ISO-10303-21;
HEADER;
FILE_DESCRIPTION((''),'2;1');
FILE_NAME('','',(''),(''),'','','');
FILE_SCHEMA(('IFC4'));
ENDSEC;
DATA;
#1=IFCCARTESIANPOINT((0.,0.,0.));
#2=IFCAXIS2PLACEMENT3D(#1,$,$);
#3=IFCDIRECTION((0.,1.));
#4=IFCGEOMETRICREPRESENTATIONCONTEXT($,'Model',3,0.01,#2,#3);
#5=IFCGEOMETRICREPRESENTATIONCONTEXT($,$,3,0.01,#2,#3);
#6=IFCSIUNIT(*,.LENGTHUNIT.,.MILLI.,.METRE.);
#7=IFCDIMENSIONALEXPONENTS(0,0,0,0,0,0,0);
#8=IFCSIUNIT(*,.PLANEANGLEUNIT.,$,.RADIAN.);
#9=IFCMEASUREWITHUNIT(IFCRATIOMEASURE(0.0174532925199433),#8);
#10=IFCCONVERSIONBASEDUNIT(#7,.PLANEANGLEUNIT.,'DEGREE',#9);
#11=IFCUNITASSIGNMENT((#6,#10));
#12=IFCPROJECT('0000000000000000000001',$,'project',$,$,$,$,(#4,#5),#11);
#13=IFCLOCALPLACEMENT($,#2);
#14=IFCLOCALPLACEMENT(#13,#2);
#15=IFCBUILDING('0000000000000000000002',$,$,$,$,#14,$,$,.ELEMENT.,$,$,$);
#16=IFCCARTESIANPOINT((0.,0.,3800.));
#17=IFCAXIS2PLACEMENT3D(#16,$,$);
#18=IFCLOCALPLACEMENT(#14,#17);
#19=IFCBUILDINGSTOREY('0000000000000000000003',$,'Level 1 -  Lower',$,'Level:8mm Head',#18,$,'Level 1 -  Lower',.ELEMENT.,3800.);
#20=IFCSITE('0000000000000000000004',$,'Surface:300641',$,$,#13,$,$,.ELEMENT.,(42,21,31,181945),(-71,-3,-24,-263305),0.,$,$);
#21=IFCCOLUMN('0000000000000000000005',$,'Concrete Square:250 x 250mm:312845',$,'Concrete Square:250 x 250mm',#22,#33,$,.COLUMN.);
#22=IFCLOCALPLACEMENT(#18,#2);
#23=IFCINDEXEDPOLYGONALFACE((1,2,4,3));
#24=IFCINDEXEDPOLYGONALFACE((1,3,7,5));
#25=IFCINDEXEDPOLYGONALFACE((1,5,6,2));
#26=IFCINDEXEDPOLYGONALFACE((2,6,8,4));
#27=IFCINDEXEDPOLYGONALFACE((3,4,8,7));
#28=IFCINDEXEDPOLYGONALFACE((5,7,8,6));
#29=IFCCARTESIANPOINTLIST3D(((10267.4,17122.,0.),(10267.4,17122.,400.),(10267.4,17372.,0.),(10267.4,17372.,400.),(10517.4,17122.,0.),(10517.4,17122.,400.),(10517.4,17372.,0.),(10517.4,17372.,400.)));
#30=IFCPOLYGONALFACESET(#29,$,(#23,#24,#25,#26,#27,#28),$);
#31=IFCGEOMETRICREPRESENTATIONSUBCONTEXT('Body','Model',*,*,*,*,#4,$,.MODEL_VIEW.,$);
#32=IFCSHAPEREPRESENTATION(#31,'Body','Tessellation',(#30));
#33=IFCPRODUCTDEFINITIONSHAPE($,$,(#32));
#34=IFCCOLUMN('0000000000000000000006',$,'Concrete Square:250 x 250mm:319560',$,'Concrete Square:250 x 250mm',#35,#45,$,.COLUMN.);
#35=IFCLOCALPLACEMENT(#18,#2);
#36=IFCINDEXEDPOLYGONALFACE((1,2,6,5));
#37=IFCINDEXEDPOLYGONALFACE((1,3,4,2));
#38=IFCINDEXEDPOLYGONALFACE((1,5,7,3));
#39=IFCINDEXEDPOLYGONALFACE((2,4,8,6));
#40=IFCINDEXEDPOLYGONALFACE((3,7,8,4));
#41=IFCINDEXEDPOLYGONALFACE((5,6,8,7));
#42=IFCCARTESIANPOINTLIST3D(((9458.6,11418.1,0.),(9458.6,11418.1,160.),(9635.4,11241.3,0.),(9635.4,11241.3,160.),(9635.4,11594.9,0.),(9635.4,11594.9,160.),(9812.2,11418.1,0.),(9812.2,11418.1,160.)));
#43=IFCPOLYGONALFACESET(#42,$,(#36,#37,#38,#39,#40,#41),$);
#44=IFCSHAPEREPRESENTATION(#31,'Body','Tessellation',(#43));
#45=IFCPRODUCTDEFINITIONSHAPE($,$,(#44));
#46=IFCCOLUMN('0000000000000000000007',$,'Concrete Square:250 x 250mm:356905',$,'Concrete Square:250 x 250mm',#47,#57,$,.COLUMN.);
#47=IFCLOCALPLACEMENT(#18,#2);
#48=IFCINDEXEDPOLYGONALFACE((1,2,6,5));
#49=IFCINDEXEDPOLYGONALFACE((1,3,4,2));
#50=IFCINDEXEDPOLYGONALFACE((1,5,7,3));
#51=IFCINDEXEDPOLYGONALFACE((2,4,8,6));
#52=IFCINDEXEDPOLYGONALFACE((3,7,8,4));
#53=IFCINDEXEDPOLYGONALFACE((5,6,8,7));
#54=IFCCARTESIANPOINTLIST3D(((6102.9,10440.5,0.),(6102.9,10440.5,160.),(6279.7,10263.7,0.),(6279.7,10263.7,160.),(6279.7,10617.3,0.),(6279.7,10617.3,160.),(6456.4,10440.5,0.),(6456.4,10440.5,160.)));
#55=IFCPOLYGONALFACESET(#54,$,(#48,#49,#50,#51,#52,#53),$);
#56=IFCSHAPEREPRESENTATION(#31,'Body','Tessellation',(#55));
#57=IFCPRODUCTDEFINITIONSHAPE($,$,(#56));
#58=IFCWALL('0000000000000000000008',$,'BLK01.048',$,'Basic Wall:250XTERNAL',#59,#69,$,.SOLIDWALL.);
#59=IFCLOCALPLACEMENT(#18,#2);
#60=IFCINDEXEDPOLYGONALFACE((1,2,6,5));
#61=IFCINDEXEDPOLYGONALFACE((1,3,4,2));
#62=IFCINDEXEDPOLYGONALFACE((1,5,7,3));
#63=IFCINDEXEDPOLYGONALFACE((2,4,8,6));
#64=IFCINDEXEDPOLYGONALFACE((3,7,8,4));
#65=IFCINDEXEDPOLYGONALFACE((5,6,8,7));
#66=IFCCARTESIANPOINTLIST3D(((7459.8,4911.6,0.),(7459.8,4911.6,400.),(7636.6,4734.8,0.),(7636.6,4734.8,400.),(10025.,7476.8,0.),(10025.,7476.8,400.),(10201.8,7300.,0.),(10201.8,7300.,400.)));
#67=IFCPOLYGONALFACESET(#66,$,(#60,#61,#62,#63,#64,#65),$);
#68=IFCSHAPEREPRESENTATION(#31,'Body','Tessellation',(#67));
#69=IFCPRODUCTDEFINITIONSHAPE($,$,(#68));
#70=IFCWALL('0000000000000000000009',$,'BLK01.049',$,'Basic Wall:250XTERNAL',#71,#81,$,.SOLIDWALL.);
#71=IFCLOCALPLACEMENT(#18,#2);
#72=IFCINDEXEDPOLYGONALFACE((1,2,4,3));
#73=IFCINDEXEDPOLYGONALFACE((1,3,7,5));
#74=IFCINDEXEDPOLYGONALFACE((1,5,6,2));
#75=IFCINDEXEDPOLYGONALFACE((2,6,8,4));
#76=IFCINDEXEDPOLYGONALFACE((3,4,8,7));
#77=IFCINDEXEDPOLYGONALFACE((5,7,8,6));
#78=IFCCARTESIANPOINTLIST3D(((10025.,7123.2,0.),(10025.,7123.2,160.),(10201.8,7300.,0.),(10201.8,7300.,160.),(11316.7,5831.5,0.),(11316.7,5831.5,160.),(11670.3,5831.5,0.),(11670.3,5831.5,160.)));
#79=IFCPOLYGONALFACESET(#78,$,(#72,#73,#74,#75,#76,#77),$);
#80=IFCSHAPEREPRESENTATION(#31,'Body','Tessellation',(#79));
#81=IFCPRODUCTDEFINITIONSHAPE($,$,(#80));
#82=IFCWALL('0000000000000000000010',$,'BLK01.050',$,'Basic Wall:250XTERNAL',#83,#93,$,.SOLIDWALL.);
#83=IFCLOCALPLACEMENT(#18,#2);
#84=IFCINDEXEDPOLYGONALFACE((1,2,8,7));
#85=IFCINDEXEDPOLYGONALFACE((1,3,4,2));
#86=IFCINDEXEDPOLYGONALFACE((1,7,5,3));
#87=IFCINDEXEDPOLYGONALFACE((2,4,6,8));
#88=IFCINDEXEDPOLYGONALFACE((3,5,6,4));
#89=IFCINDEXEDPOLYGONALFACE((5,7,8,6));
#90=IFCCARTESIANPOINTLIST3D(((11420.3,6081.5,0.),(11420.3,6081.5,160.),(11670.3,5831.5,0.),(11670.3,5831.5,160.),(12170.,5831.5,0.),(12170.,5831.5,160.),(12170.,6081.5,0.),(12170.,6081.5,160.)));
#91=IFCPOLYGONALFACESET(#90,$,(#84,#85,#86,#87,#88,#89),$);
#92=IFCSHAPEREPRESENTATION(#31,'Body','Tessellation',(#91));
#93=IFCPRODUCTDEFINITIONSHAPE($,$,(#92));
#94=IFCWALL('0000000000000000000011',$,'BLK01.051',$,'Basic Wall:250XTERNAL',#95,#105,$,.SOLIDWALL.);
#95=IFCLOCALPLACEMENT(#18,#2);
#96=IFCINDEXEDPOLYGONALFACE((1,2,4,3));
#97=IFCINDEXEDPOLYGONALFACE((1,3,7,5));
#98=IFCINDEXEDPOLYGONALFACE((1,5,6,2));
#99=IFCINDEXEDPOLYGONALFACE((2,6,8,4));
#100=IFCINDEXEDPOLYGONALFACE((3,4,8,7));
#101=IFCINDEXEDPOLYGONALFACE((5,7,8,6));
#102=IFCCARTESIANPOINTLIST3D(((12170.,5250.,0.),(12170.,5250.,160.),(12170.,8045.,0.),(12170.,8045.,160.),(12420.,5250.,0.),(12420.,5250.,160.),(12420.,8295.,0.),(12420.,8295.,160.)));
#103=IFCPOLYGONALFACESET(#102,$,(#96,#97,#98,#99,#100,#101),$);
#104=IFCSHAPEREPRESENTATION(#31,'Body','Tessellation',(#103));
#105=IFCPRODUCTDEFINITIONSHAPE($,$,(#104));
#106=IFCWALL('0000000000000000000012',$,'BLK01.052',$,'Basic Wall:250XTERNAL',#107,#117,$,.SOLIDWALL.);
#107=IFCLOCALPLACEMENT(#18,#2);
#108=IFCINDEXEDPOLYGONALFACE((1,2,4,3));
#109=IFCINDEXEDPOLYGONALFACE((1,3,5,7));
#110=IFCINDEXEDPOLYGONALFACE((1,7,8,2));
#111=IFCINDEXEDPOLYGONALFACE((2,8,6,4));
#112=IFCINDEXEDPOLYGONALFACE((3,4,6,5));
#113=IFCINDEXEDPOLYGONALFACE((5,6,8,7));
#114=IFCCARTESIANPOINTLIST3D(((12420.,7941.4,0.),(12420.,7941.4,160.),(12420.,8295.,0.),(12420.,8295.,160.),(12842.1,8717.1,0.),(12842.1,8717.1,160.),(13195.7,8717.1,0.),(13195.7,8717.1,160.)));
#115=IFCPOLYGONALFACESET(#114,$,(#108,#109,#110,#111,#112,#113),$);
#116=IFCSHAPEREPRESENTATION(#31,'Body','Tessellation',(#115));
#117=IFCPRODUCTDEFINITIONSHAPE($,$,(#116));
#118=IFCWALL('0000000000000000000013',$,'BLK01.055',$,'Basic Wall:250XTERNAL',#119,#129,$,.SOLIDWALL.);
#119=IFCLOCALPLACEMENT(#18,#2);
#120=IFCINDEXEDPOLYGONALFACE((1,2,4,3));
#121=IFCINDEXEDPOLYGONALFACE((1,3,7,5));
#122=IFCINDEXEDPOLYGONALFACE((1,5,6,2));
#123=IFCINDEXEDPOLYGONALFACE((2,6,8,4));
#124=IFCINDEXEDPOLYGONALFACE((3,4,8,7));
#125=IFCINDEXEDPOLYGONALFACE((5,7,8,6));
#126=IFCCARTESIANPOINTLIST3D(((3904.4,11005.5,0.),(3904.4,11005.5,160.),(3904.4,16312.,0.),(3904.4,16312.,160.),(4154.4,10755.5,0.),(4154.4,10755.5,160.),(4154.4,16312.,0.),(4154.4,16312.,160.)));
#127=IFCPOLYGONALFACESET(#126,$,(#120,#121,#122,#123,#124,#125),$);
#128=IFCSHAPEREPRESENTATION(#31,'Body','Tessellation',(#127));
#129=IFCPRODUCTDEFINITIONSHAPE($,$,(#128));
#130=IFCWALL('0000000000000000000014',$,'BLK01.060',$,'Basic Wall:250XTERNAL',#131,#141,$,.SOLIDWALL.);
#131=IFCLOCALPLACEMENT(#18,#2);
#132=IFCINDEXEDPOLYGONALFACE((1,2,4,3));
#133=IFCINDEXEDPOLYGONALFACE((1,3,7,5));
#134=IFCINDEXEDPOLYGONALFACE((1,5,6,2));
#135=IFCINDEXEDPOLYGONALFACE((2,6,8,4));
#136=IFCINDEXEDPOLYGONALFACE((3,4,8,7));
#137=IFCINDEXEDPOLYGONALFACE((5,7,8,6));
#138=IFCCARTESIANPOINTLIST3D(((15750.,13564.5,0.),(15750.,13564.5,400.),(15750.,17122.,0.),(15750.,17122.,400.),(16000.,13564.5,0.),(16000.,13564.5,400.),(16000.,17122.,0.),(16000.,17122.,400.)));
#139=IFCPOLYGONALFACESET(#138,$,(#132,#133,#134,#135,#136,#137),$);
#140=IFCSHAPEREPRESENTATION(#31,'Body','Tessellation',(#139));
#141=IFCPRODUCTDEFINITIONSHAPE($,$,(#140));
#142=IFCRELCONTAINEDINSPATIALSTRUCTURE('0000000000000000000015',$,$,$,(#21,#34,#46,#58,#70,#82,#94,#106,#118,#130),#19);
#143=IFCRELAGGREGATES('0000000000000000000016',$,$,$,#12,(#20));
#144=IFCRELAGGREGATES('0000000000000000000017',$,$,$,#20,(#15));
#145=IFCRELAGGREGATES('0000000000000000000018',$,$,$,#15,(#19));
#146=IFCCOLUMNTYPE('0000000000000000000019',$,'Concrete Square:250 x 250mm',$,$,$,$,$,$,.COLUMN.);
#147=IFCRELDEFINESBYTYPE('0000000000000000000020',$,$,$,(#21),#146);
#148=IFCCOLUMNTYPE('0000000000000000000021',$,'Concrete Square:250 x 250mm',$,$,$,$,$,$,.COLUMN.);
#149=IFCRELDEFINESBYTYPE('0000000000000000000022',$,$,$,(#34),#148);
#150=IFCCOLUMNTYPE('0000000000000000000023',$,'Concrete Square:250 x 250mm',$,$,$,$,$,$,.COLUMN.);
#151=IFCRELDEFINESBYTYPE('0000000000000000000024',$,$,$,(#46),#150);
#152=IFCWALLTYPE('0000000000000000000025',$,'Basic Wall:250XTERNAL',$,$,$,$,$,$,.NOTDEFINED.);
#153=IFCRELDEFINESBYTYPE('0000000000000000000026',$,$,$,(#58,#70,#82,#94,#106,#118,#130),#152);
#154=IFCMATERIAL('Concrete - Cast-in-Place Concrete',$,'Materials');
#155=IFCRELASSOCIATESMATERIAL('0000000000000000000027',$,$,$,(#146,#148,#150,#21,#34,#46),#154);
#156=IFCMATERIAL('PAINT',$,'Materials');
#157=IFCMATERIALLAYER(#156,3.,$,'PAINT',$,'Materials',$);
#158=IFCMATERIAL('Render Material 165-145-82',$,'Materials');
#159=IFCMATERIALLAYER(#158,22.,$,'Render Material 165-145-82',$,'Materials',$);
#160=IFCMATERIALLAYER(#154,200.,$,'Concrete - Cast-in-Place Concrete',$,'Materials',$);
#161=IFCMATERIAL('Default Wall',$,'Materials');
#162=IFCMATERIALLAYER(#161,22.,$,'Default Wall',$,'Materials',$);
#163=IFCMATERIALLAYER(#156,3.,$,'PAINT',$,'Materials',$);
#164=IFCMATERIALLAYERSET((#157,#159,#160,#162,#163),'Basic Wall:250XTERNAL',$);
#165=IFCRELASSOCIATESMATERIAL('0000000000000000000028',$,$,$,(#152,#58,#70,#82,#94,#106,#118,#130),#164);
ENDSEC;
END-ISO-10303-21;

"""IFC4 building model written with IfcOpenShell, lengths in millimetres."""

from ifc_helpers import new_model, entity, si_unit, converted_unit, direction, frame, frame_2d, origin, origin_2d_with_axis, place, context, subcontext, project, spatial, polyline, rectangle, outline, extrude, clip, halfspace, bounded_halfspace, source, transform, mapped, material, layer, layer_set, layer_usage, material_profile, profile_set, profile_usage, type_object, type_shapes, element, save


model = new_model("IFC4")

# Units and contexts
model_context = context("Model", 3, precision=0.01, world=origin(), true_north=direction((0.0, 1.0)))
context_of_model = context(None, 3, precision=0.01, world=origin(), true_north=direction((0.0, 1.0)))
body_context = subcontext(model_context, "Body", "Model", "MODEL_VIEW")
ifc_project = project(units=[si_unit("LENGTHUNIT", "METRE", prefix="MILLI"), converted_unit("PLANEANGLEUNIT", "DEGREE", entity("IfcRatioMeasure", 0.0174532925199433), si_unit("PLANEANGLEUNIT", "RADIAN"), dimensions=[0, 0, 0, 0, 0, 0, 0])], contexts=[model_context, context_of_model])

# Site, building, storey
site_placement = place(None, origin())
site = spatial("IfcSite", under=ifc_project, at=site_placement, Name="Surface:300641", CompositionType="ELEMENT", RefLatitude=(42, 21, 31, 181945), RefLongitude=(-71, -3, -24, -263305), RefElevation=0.0)
building_placement = place(site_placement, origin())
building = spatial("IfcBuilding", under=site, at=building_placement, CompositionType="ELEMENT")
storey_placement = place(building_placement, frame((0.0, 0.0, 3800.0)))
storey = spatial("IfcBuildingStorey", under=building, at=storey_placement, Name="Level 1 -  Lower", ObjectType="Level:8mm Head", LongName="Level 1 -  Lower", CompositionType="ELEMENT", Elevation=3800.0)

# Columns
ifc_material_1 = material(Name="Concrete - Cast-in-Place Concrete", Category="Materials")
ifc_material_profile_1 = material_profile(ifc_material_1, rectangle(XDim=250.0, YDim=250.0, at=frame_2d((0.0, 0.0), x_axis=(1.0, 0.0))), Name="250 x 250mm")
ifc_profile_set_1 = profile_set([ifc_material_profile_1], Name="250 x 250mm")
ifc_profile_usage_1 = profile_usage(ifc_profile_set_1)
column_type_1 = type_object("IfcColumnType", Name="Concrete Square:250 x 250mm", PredefinedType="COLUMN", material=ifc_profile_set_1)
shared_shape_1 = source(origin(), body_context, "Body", "SweptSolid", [
    extrude(rectangle(XDim=250.0, YDim=250.0, at=origin_2d_with_axis()), frame((10392.4, 17247.0, 3800.0), z_axis=(0.0, 0.0, 1.0), x_axis=(0.0, -1.0, 0.0)), (0.0, 0.0, 1.0), 400.0),
])
type_shapes(column_type_1, [shared_shape_1])
column_1_placement = place(storey_placement, frame((0.0, 0.0, -3800.0)))
element("IfcColumn", 1, at=column_1_placement, inside=storey, type_object=column_type_1, material=ifc_profile_usage_1, Name="Concrete Square:250 x 250mm:312845", ObjectType="Concrete Square:250 x 250mm", PredefinedType="COLUMN", context=body_context, shape_type="MappedRepresentation", body=[
    mapped(shared_shape_1, transform((0.0, 0.0, 0.0), scale=1.0)),
])
ifc_profile_usage_2 = profile_usage(ifc_profile_set_1)
column_type_2 = type_object("IfcColumnType", Name="Concrete Square:250 x 250mm", PredefinedType="COLUMN", material=ifc_profile_set_1)
shared_shape_2 = source(origin(), body_context, "Body", "SweptSolid", [
    extrude(rectangle(XDim=250.0, YDim=250.0, at=frame_2d((0.0, 0.0), x_axis=(1.0, 0.0))), frame((9635.4, 11418.1, 3800.0), z_axis=(0.0, 0.0, 1.0), x_axis=(-0.707107, 0.707107, 0.0)), (0.0, 0.0, 1.0), 160.0),
])
type_shapes(column_type_2, [shared_shape_2])
column_2_placement = place(storey_placement, frame((0.0, 0.0, -3800.0)))
element("IfcColumn", 2, at=column_2_placement, inside=storey, type_object=column_type_2, material=ifc_profile_usage_2, Name="Concrete Square:250 x 250mm:319560", ObjectType="Concrete Square:250 x 250mm", PredefinedType="COLUMN", context=body_context, shape_type="MappedRepresentation", body=[
    mapped(shared_shape_2, transform((0.0, 0.0, 0.0), scale=1.0)),
])
ifc_profile_usage_3 = profile_usage(ifc_profile_set_1)
column_type_3 = type_object("IfcColumnType", Name="Concrete Square:250 x 250mm", PredefinedType="COLUMN", material=ifc_profile_set_1)
shared_shape_3 = source(origin(), body_context, "Body", "SweptSolid", [
    extrude(rectangle(XDim=250.0, YDim=250.0, at=origin_2d_with_axis()), frame((6279.7, 10440.5, 3800.0), z_axis=(0.0, 0.0, 1.0), x_axis=(-0.707107, 0.707107, 0.0)), (0.0, 0.0, 1.0), 160.0),
])
type_shapes(column_type_3, [shared_shape_3])
column_3_placement = place(storey_placement, frame((0.0, 0.0, -3800.0)))
element("IfcColumn", 3, at=column_3_placement, inside=storey, type_object=column_type_3, material=ifc_profile_usage_3, Name="Concrete Square:250 x 250mm:356905", ObjectType="Concrete Square:250 x 250mm", PredefinedType="COLUMN", context=body_context, shape_type="MappedRepresentation", body=[
    mapped(shared_shape_3, transform((0.0, 0.0, 0.0), scale=1.0)),
])

# Walls
ifc_material_2 = material(Name="PAINT", Category="Materials")
ifc_layer_1 = layer(ifc_material_2, 3.0, Name="PAINT", Category="Materials")
ifc_material_3 = material(Name="Render Material 165-145-82", Category="Materials")
ifc_layer_2 = layer(ifc_material_3, 22.0, Name="Render Material 165-145-82", Category="Materials")
ifc_layer_3 = layer(ifc_material_1, 200.0, Name="Concrete - Cast-in-Place Concrete", Category="Materials")
ifc_material_4 = material(Name="Default Wall", Category="Materials")
ifc_layer_4 = layer(ifc_material_4, 22.0, Name="Default Wall", Category="Materials")
ifc_layer_5 = layer(ifc_material_2, 3.0, Name="PAINT", Category="Materials")
ifc_layer_set_1 = layer_set([ifc_layer_1, ifc_layer_2, ifc_layer_3, ifc_layer_4, ifc_layer_5], Name="Basic Wall:250XTERNAL")
wall_type_1 = type_object("IfcWallType", Name="Basic Wall:250XTERNAL", PredefinedType="NOTDEFINED", material=ifc_layer_set_1)
ifc_layer_usage_1 = layer_usage(ifc_layer_set_1, "AXIS2", "NEGATIVE", 125.0)
wall_1_placement = place(storey_placement, frame((7548.2, 4823.2, 0.0), z_axis=(0.0, 0.0, 1.0), x_axis=(0.707107, 0.707107, 0.0)))
element("IfcWall", 4, at=wall_1_placement, inside=storey, type_object=wall_type_1, material=ifc_layer_usage_1, Name="BLK01.048", ObjectType="Basic Wall:250XTERNAL", PredefinedType="SOLIDWALL", context=body_context, shape_type="Clipping", body=[
    clip(extrude(rectangle(XDim=3627.7, YDim=250.0, at=frame_2d((1813.8, 0.0), x_axis=(-1.0, 0.0))), origin(), (0.0, 0.0, 1.0), 400.0), halfspace(frame((0.0, 0.0, -3200.0)), True)),
])
ifc_layer_usage_2 = layer_usage(ifc_layer_set_1, "AXIS2", "NEGATIVE", 125.0)
wall_2_placement = place(storey_placement, frame((10113.4, 7211.6, 0.0), z_axis=(0.0, 0.0, 1.0), x_axis=(0.707107, -0.707107, 0.0)))
element("IfcWall", 5, at=wall_2_placement, inside=storey, type_object=wall_type_1, material=ifc_layer_usage_2, Name="BLK01.049", ObjectType="Basic Wall:250XTERNAL", PredefinedType="SOLIDWALL", context=body_context, shape_type="Clipping", body=[
    clip(clip(extrude(outline(polyline([(0.0, -125.0), (1826.8, -125.0), (2076.8, 125.0), (1723.2, 125.0), (0.0, 125.0), (0.0, -125.0)])), origin(), (0.0, 0.0, 1.0), 160.0), bounded_halfspace(frame((0.0, -125.0, 160.0), z_axis=(0.0, 0.0, -1.0), x_axis=(0.707107, -0.707107, 0.0)), True, frame((0.0, -125.0, 160.0)), polyline([(0.0, 0.0), (1826.8, 0.0), (2076.8, 250.0), (1723.2, 250.0), (0.0, 250.0), (0.0, 0.0)]))), halfspace(frame((0.0, 0.0, -3200.0)), True)),
])
ifc_layer_usage_3 = layer_usage(ifc_layer_set_1, "AXIS2", "NEGATIVE", 125.0)
wall_3_placement = place(storey_placement, frame((11420.3, 5956.5, 0.0)))
element("IfcWall", 6, at=wall_3_placement, inside=storey, type_object=wall_type_1, material=ifc_layer_usage_3, Name="BLK01.050", ObjectType="Basic Wall:250XTERNAL", PredefinedType="SOLIDWALL", context=body_context, shape_type="Clipping", body=[
    clip(clip(extrude(outline(polyline([(749.7, -125.0), (749.7, 125.0), (0.0, 125.0), (250.0, -125.0), (749.7, -125.0)])), origin(), (0.0, 0.0, 1.0), 160.0), bounded_halfspace(frame((250.0, -125.0, 160.0), z_axis=(0.0, 0.0, -1.0), x_axis=(0.0, -1.0, 0.0)), True, frame((250.0, -125.0, 160.0)), polyline([(0.0, 0.0), (499.7, 0.0), (499.7, 250.0), (-250.0, 250.0), (0.0, 0.0)]))), halfspace(frame((0.0, 0.0, -3200.0)), True)),
])
ifc_layer_usage_4 = layer_usage(ifc_layer_set_1, "AXIS2", "NEGATIVE", 125.0)
wall_4_placement = place(storey_placement, frame((12295.0, 5250.0, 0.0), z_axis=(0.0, 0.0, 1.0), x_axis=(0.0, 1.0, 0.0)))
element("IfcWall", 7, at=wall_4_placement, inside=storey, type_object=wall_type_1, material=ifc_layer_usage_4, Name="BLK01.051", ObjectType="Basic Wall:250XTERNAL", PredefinedType="SOLIDWALL", context=body_context, shape_type="Clipping", body=[
    clip(clip(extrude(outline(polyline([(3045.0, -125.0), (2795.0, 125.0), (831.5, 125.0), (581.5, 125.0), (0.0, 125.0), (0.0, -125.0), (2691.4, -125.0), (3045.0, -125.0)])), origin(), (0.0, 0.0, 1.0), 160.0), bounded_halfspace(frame((0.0, -125.0, 160.0), z_axis=(0.0, 0.0, -1.0), x_axis=(-1.0, 0.0, 0.0)), True, frame((0.0, -125.0, 160.0)), polyline([(0.0, 0.0), (2691.4, 0.0), (3045.0, 0.0), (2795.0, 250.0), (831.5, 250.0), (581.5, 250.0), (0.0, 250.0), (0.0, 0.0)]))), halfspace(frame((0.0, 0.0, -3200.0)), True)),
])
ifc_layer_usage_5 = layer_usage(ifc_layer_set_1, "AXIS2", "NEGATIVE", 125.0)
wall_5_placement = place(storey_placement, frame((12331.6, 8029.8, 0.0), z_axis=(0.0, 0.0, 1.0), x_axis=(0.707107, 0.707107, 0.0)))
element("IfcWall", 8, at=wall_5_placement, inside=storey, type_object=wall_type_1, material=ifc_layer_usage_5, Name="BLK01.052", ObjectType="Basic Wall:250XTERNAL", PredefinedType="SOLIDWALL", context=body_context, shape_type="Clipping", body=[
    clip(clip(extrude(outline(polyline([(1097.0, -125.0), (847.0, 125.0), (250.0, 125.0), (0.0, -125.0), (1097.0, -125.0)])), origin(), (0.0, 0.0, 1.0), 160.0), bounded_halfspace(frame((0.0, -125.0, 160.0), z_axis=(0.0, 0.0, -1.0), x_axis=(-0.707107, -0.707107, 0.0)), True, frame((0.0, -125.0, 160.0)), polyline([(0.0, 0.0), (1097.0, 0.0), (847.0, 250.0), (250.0, 250.0), (0.0, 0.0)]))), halfspace(frame((0.0, 0.0, -3200.0)), True)),
])
ifc_layer_usage_6 = layer_usage(ifc_layer_set_1, "AXIS2", "NEGATIVE", 125.0)
wall_6_placement = place(storey_placement, frame((4029.4, 10755.5, 0.0), z_axis=(0.0, 0.0, 1.0), x_axis=(0.0, 1.0, 0.0)))
element("IfcWall", 9, at=wall_6_placement, inside=storey, type_object=wall_type_1, material=ifc_layer_usage_6, Name="BLK01.055", ObjectType="Basic Wall:250XTERNAL", PredefinedType="SOLIDWALL", context=body_context, shape_type="Clipping", body=[
    clip(clip(extrude(outline(polyline([(5556.5, -125.0), (5556.5, 125.0), (250.0, 125.0), (0.0, -125.0), (5306.5, -125.0), (5556.5, -125.0)])), origin(), (0.0, 0.0, 1.0), 160.0), bounded_halfspace(frame((0.0, -125.0, 160.0), z_axis=(0.0, 0.0, -1.0), x_axis=(-1.0, 0.0, 0.0)), True, frame((0.0, -125.0, 160.0)), polyline([(0.0, 0.0), (5306.5, 0.0), (5531.5, 0.0), (5531.5, 225.0), (225.0, 225.0), (0.0, 0.0)]))), halfspace(frame((0.0, 0.0, -3200.0)), True)),
])

# Wall
ifc_layer_usage_7 = layer_usage(ifc_layer_set_1, "AXIS2", "NEGATIVE", 125.0)
wall_7_placement = place(storey_placement, frame((15875.0, 17122.0, 0.0), z_axis=(0.0, 0.0, 1.0), x_axis=(0.0, -1.0, 0.0)))
element("IfcWall", 10, at=wall_7_placement, inside=storey, type_object=wall_type_1, material=ifc_layer_usage_7, Name="BLK01.060", ObjectType="Basic Wall:250XTERNAL", PredefinedType="SOLIDWALL", context=body_context, shape_type="Clipping", body=[
    clip(extrude(rectangle(XDim=3557.5, YDim=250.0, at=frame_2d((1778.8, 0.0), x_axis=(-1.0, 0.0))), origin(), (0.0, 0.0, 1.0), 400.0), halfspace(origin(), True)),
])

save(model, "model.ifc")
